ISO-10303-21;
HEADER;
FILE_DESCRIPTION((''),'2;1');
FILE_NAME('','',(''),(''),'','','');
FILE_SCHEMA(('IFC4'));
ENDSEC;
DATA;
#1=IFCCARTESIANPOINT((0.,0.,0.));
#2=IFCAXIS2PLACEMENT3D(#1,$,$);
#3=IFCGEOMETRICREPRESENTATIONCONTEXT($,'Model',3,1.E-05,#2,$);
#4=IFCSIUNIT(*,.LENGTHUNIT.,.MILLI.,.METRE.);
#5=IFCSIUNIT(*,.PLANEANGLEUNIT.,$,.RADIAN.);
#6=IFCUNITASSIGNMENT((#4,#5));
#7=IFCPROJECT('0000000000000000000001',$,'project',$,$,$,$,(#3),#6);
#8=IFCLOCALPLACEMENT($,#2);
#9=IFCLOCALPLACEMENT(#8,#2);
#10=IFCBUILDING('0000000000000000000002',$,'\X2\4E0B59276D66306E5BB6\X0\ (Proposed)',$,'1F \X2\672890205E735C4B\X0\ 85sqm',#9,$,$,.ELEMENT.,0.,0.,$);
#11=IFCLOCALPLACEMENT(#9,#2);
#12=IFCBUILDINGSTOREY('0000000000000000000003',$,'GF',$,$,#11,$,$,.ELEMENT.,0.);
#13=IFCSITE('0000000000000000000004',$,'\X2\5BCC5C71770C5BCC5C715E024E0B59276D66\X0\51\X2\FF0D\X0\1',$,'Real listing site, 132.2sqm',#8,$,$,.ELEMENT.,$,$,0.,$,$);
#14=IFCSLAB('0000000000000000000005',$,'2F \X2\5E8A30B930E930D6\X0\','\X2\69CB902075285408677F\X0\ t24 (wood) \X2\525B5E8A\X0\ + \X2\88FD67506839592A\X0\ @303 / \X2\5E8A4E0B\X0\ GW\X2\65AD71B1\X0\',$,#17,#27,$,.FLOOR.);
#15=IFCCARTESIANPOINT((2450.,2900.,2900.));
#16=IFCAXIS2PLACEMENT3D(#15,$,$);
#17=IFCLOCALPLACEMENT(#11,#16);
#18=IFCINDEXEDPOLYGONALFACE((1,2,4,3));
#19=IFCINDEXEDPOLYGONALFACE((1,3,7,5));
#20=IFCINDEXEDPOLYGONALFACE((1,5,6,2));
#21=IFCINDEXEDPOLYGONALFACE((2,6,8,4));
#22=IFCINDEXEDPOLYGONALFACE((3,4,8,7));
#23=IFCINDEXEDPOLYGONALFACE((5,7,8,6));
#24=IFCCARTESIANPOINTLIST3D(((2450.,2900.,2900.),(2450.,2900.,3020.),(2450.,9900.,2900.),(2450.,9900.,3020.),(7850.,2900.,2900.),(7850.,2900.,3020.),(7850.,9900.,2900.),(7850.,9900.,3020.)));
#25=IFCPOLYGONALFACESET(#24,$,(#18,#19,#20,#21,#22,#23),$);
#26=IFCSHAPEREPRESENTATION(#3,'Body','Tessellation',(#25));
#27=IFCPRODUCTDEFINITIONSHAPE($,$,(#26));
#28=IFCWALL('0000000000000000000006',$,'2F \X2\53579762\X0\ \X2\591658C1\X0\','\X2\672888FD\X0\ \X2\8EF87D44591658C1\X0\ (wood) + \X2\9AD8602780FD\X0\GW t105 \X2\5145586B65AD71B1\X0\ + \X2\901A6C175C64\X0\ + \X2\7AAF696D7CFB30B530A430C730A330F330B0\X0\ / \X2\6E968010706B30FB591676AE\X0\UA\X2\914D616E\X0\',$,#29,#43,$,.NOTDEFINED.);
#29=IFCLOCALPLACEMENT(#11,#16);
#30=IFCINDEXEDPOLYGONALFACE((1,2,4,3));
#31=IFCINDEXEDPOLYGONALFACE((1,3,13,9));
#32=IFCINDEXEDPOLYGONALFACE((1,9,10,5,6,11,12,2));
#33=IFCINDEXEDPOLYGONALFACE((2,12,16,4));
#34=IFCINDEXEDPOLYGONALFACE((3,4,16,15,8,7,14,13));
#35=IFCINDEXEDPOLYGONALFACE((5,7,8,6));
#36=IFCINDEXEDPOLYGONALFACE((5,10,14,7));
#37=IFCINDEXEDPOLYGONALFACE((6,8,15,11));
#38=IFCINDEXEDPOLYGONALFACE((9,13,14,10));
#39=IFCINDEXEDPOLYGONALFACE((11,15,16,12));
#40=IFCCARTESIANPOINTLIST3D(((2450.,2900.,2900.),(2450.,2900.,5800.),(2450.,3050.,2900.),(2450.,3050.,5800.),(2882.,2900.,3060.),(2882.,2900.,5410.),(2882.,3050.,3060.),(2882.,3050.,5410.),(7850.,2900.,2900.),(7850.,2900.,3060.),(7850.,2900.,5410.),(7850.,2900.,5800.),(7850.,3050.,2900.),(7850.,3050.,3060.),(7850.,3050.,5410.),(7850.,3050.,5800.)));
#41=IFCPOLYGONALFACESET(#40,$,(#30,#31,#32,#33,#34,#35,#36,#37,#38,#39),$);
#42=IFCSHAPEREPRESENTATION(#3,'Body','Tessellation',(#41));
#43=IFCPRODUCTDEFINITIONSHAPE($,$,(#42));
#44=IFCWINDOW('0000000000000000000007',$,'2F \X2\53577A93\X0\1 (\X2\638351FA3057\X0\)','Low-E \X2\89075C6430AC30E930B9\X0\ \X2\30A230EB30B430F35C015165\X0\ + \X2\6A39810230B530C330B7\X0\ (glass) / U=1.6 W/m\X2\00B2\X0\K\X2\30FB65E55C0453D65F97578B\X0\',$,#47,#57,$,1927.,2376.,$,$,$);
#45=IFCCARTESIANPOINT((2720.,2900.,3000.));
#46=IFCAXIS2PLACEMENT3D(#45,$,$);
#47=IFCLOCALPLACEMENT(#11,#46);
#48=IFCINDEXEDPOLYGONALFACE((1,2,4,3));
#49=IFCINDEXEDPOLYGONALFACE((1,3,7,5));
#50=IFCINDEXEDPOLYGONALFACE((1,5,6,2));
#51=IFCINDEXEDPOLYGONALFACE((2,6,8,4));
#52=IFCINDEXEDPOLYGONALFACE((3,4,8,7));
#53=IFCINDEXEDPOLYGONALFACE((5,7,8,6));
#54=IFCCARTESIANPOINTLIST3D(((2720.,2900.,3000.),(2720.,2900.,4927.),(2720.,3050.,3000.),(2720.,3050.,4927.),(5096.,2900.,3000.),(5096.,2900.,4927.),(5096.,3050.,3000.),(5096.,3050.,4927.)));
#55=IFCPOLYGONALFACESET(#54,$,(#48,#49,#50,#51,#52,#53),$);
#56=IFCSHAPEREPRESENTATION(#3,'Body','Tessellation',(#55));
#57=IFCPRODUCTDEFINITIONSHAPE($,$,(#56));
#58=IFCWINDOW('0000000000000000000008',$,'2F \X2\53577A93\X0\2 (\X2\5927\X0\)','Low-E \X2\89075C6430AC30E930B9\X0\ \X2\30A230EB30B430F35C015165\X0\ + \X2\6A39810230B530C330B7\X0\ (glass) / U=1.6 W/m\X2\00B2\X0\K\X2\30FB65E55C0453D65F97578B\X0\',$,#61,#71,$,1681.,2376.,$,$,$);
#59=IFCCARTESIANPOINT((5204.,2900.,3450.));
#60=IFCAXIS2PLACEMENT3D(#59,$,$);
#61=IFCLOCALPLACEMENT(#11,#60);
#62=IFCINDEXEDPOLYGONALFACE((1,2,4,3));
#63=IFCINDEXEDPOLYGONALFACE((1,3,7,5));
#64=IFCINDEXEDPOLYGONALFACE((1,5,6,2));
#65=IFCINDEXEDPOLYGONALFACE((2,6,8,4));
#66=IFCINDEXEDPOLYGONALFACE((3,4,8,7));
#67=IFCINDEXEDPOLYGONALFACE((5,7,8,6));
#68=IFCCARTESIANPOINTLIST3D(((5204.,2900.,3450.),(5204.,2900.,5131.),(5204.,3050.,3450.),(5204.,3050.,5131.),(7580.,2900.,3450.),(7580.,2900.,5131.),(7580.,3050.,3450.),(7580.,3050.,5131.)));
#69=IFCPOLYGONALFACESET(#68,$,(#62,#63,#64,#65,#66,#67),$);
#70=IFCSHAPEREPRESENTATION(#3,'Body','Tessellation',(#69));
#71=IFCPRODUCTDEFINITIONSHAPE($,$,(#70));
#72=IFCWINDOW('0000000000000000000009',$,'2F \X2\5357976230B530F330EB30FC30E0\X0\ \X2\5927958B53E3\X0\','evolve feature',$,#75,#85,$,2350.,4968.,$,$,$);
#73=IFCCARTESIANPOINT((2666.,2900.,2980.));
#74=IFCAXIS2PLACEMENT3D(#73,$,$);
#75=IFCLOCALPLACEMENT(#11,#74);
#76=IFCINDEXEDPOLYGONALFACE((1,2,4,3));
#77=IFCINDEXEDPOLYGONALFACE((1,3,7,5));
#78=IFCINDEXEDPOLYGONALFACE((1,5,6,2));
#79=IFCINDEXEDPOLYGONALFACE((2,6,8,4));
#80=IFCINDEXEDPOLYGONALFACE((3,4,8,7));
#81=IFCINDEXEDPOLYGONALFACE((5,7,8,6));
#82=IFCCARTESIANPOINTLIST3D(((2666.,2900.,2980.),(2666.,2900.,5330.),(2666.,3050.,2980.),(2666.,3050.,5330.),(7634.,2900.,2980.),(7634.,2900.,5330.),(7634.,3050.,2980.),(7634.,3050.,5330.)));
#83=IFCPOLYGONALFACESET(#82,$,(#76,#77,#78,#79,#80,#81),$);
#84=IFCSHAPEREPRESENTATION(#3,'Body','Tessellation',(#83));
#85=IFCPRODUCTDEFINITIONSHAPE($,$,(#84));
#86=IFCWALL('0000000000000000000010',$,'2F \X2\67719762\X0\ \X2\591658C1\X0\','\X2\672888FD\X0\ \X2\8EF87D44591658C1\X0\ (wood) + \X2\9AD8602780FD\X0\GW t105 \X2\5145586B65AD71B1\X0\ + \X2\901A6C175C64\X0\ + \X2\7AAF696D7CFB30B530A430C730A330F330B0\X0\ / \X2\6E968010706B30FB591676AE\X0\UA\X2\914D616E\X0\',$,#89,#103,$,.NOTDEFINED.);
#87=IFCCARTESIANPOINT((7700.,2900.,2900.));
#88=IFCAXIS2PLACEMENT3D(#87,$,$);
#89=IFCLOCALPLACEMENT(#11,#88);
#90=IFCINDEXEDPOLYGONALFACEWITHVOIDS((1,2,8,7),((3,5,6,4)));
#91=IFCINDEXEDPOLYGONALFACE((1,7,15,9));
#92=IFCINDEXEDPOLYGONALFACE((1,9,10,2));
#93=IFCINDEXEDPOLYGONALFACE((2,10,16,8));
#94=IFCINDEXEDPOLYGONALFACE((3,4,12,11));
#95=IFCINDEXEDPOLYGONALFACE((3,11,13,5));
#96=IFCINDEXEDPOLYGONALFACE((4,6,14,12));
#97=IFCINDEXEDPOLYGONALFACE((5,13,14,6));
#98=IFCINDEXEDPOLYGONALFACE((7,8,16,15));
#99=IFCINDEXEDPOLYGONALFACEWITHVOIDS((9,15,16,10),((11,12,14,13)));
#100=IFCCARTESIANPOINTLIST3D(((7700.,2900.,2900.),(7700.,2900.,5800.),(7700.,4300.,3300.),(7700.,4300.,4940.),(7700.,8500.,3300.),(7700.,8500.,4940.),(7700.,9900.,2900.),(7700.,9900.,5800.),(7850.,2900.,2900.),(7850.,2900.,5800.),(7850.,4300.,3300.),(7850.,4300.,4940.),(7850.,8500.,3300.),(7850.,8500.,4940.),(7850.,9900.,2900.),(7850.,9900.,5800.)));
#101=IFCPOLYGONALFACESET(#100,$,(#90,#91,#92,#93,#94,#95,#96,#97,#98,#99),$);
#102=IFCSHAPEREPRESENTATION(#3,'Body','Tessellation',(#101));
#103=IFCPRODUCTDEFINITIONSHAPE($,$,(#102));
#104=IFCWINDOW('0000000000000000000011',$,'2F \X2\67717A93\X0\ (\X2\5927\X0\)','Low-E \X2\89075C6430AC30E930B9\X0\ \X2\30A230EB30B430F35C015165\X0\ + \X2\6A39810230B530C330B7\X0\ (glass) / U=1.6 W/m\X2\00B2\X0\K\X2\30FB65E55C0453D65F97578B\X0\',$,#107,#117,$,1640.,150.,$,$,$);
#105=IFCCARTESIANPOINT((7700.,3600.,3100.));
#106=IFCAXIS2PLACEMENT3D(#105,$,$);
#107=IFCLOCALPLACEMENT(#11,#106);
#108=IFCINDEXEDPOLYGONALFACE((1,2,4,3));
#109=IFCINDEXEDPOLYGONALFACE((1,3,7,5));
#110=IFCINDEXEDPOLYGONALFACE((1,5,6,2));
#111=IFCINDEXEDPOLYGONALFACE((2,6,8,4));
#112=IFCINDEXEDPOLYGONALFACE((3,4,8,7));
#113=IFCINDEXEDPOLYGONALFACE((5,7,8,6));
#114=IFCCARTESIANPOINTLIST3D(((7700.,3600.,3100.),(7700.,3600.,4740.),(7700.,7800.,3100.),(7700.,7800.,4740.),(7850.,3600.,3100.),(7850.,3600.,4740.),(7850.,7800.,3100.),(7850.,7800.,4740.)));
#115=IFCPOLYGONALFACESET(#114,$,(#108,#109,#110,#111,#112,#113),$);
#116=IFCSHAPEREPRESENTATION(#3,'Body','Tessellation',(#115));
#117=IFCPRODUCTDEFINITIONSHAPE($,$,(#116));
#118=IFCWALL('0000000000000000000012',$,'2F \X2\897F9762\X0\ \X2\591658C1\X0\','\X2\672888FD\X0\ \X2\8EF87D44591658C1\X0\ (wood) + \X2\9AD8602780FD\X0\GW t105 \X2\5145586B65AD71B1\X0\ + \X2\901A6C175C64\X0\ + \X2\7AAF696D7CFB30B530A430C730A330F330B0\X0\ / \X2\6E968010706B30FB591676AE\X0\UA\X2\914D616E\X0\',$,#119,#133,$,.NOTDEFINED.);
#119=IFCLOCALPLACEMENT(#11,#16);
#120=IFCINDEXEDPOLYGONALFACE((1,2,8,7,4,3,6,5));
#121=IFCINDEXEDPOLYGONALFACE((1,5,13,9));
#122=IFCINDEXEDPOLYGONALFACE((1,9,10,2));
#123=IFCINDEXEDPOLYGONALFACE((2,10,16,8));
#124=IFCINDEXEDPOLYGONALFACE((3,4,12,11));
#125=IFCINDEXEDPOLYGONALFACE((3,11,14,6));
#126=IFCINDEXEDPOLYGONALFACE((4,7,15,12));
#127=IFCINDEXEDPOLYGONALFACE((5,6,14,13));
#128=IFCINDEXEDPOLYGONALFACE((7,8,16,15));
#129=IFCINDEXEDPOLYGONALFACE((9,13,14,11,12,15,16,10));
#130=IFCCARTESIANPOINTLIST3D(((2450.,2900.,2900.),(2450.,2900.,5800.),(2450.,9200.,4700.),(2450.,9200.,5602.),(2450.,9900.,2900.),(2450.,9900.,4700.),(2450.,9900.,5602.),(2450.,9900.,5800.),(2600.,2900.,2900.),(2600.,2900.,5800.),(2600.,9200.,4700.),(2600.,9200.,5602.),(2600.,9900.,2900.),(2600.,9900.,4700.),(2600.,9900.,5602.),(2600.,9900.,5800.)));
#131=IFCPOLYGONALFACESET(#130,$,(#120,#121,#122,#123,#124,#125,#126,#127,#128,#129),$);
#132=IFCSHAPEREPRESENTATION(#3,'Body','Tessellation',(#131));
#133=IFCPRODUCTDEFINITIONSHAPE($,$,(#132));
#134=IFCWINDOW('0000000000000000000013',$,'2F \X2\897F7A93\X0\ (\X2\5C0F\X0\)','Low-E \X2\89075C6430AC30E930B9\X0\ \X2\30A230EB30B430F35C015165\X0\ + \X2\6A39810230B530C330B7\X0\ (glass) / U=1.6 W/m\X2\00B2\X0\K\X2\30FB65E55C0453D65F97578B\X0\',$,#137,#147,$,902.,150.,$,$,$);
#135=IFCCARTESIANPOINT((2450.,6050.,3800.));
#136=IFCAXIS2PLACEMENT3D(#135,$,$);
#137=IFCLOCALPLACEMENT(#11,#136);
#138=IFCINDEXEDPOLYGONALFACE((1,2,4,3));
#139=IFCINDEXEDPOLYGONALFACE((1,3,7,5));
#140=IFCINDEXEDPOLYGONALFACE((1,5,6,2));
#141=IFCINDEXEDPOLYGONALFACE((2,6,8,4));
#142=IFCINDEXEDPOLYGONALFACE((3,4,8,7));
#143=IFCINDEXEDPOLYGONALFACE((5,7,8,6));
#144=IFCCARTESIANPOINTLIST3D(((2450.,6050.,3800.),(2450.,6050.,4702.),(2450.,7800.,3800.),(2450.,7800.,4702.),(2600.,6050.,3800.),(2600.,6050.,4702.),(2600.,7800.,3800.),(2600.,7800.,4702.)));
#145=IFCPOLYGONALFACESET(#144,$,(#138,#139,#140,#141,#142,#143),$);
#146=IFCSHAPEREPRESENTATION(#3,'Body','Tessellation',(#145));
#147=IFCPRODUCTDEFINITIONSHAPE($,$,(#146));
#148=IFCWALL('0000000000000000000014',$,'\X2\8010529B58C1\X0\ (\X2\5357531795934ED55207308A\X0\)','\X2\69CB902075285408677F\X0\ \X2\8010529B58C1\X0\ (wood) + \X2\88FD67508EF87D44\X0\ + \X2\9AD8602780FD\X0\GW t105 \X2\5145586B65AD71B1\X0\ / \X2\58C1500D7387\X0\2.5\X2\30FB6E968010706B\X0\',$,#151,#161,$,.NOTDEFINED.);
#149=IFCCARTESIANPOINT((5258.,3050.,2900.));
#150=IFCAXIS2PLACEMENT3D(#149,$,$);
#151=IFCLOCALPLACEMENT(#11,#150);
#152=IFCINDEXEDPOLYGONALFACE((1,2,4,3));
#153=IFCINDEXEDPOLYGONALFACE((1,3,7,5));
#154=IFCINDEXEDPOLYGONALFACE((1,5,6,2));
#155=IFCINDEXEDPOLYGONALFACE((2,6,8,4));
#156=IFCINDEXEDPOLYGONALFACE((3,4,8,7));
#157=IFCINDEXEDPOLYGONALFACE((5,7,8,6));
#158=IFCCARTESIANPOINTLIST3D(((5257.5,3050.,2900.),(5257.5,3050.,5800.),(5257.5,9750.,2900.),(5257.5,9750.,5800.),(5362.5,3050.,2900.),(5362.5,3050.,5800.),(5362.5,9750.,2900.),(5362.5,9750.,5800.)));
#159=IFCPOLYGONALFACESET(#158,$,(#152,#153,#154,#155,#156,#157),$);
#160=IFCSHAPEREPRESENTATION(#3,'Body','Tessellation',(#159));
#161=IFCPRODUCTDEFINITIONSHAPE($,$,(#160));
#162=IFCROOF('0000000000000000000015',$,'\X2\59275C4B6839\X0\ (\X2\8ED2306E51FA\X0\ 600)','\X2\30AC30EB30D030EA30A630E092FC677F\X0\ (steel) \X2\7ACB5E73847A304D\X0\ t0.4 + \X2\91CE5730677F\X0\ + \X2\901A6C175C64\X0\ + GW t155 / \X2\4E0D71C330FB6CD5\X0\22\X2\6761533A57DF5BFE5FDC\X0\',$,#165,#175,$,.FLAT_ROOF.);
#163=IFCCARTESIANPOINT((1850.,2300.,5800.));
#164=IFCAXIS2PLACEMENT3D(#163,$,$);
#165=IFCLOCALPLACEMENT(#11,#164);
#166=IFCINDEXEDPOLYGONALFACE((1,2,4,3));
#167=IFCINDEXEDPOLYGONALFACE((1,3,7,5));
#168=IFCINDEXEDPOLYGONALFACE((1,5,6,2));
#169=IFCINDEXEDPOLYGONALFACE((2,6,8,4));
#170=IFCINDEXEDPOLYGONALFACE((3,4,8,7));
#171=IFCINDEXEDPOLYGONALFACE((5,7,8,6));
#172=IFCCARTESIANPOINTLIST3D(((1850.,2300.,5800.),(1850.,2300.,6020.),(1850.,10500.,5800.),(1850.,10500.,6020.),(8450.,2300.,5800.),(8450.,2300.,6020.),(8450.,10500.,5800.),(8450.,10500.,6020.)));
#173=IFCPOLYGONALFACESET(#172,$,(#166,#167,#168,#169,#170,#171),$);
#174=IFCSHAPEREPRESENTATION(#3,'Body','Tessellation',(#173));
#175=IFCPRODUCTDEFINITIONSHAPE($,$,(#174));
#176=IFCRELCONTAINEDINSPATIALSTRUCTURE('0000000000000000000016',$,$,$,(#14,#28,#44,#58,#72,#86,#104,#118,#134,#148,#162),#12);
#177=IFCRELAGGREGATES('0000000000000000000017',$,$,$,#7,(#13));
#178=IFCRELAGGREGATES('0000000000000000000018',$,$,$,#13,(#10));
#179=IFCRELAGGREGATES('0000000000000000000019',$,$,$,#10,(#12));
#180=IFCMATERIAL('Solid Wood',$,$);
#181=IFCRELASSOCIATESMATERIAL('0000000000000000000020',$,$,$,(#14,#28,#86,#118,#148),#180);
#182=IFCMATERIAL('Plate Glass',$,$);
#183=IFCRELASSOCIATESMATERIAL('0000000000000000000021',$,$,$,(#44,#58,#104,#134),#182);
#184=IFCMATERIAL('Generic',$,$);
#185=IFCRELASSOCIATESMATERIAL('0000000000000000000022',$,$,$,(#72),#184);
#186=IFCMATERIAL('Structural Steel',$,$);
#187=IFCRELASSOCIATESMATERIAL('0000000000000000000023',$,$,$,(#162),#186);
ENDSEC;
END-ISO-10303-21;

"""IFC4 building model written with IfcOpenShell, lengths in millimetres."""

from ifc_helpers import new_model, si_unit, frame, frame_2d, origin, place, context, project, spatial, rectangle, extrude, material, element, fill, save


model = new_model("IFC4")

# Units and contexts
model_context = context("Model", 3, precision=1e-05, world=origin())
ifc_project = project(units=[si_unit("LENGTHUNIT", "METRE", prefix="MILLI"), si_unit("PLANEANGLEUNIT", "RADIAN")], contexts=[model_context])

# Site, building, storey
site_placement = place(None, origin())
site = spatial("IfcSite", under=ifc_project, at=site_placement, Name="富山県富山市下大浦51－1", ObjectType="Real listing site, 132.2sqm", CompositionType="ELEMENT", RefElevation=0.0)
building_placement = place(site_placement, origin())
building = spatial("IfcBuilding", under=site, at=building_placement, Name="下大浦の家 (Proposed)", ObjectType="1F 木造平屋 85sqm", CompositionType="ELEMENT", ElevationOfRefHeight=0.0, ElevationOfTerrain=0.0)
storey_placement = place(building_placement, origin())
storey = spatial("IfcBuildingStorey", under=building, at=storey_placement, Name="GF", CompositionType="ELEMENT", Elevation=0.0)

# Slab
ifc_material_1 = material(Name="Solid Wood")
slab_placement = place(storey_placement, frame((2450.0, 2900.0, 2900.0)))
element("IfcSlab", 1, at=slab_placement, inside=storey, material=ifc_material_1, Name="2F 床スラブ", Description="構造用合板 t24 (wood) 剛床 + 製材根太 @303 / 床下 GW断熱", PredefinedType="FLOOR", context=model_context, shape_type="SweptSolid", body=[
    extrude(rectangle(XDim=5400.0, YDim=7000.0, at=frame_2d((2700.0, 3500.0))), frame((2450.0, 2900.0, 2900.0)), (0.0, 0.0, 1.0), 120.0),
])

# Wall, openings, windows
wall_1_placement = place(storey_placement, frame((2450.0, 2900.0, 2900.0)))
wall_1 = element("IfcWall", 2, at=wall_1_placement, inside=storey, material=ifc_material_1, Name="2F 南面 外壁", Description="木製 軸組外壁 (wood) + 高性能GW t105 充填断熱 + 通気層 + 窯業系サイディング / 準耐火・外皮UA配慮", PredefinedType="NOTDEFINED", context=model_context, shape_type="SweptSolid", body=[
    extrude(rectangle(XDim=5400.0, YDim=150.0, at=frame_2d((2700.0, 75.0))), frame((2450.0, 2900.0, 2900.0)), (0.0, 0.0, 1.0), 2900.0),
])
opening_1_placement = place(storey_placement, frame((2720.0, 2900.0, 3000.0)))
opening_1 = element("IfcOpeningElement", 3, at=opening_1_placement, cuts=wall_1, PredefinedType="NOTDEFINED", context=model_context, shape_type="SweptSolid", body=[
    extrude(rectangle(XDim=2376.0, YDim=150.0, at=frame_2d((1188.0, 75.0))), frame((2720.0, 2900.0, 3000.0)), (0.0, 0.0, 1.0), 1927.0),
])
opening_2_placement = place(storey_placement, frame((5204.0, 2900.0, 3450.0)))
opening_2 = element("IfcOpeningElement", 4, at=opening_2_placement, cuts=wall_1, PredefinedType="NOTDEFINED", context=model_context, shape_type="SweptSolid", body=[
    extrude(rectangle(XDim=2376.0, YDim=150.0, at=frame_2d((1188.0, 75.0))), frame((5204.0, 2900.0, 3450.0)), (0.0, 0.0, 1.0), 1681.0),
])
opening_3_placement = place(storey_placement, frame((2666.0, 2900.0, 2980.0)))
opening_3 = element("IfcOpeningElement", 5, at=opening_3_placement, cuts=wall_1, PredefinedType="NOTDEFINED", context=model_context, shape_type="SweptSolid", body=[
    extrude(rectangle(XDim=4968.0, YDim=150.0, at=frame_2d((2484.0, 75.0))), frame((2666.0, 2900.0, 2980.0)), (0.0, 0.0, 1.0), 2350.0),
])
ifc_material_2 = material(Name="Plate Glass")
window_1_placement = place(storey_placement, frame((2720.0, 2900.0, 3000.0)))
window_1 = element("IfcWindow", 6, at=window_1_placement, inside=storey, material=ifc_material_2, Name="2F 南窓1 (掃出し)", Description="Low-E 複層ガラス アルゴン封入 + 樹脂サッシ (glass) / U=1.6 W/m²K・日射取得型", OverallHeight=1927.0, OverallWidth=2376.0, context=model_context, shape_type="SweptSolid", body=[
    extrude(rectangle(XDim=2376.0, YDim=150.0, at=frame_2d((1188.0, 75.0))), frame((2720.0, 2900.0, 3000.0)), (0.0, 0.0, 1.0), 1927.0),
])
fill(opening_1, window_1)
window_2_placement = place(storey_placement, frame((5204.0, 2900.0, 3450.0)))
window_2 = element("IfcWindow", 7, at=window_2_placement, inside=storey, material=ifc_material_2, Name="2F 南窓2 (大)", Description="Low-E 複層ガラス アルゴン封入 + 樹脂サッシ (glass) / U=1.6 W/m²K・日射取得型", OverallHeight=1681.0, OverallWidth=2376.0, context=model_context, shape_type="SweptSolid", body=[
    extrude(rectangle(XDim=2376.0, YDim=150.0, at=frame_2d((1188.0, 75.0))), frame((5204.0, 2900.0, 3450.0)), (0.0, 0.0, 1.0), 1681.0),
])
fill(opening_2, window_2)
ifc_material_3 = material(Name="Generic")
window_3_placement = place(storey_placement, frame((2666.0, 2900.0, 2980.0)))
window_3 = element("IfcWindow", 8, at=window_3_placement, inside=storey, material=ifc_material_3, Name="2F 南面サンルーム 大開口", Description="evolve feature", OverallHeight=2350.0, OverallWidth=4968.0, context=model_context, shape_type="SweptSolid", body=[
    extrude(rectangle(XDim=4968.0, YDim=150.0, at=frame_2d((2484.0, 75.0))), frame((2666.0, 2900.0, 2980.0)), (0.0, 0.0, 1.0), 2350.0),
])
fill(opening_3, window_3)

# Walls, openings, windows
wall_2_placement = place(storey_placement, frame((7700.0, 2900.0, 2900.0)))
wall_2 = element("IfcWall", 9, at=wall_2_placement, inside=storey, material=ifc_material_1, Name="2F 東面 外壁", Description="木製 軸組外壁 (wood) + 高性能GW t105 充填断熱 + 通気層 + 窯業系サイディング / 準耐火・外皮UA配慮", PredefinedType="NOTDEFINED", context=model_context, shape_type="SweptSolid", body=[
    extrude(rectangle(XDim=150.0, YDim=7000.0, at=frame_2d((75.0, 3500.0))), frame((7700.0, 2900.0, 2900.0)), (0.0, 0.0, 1.0), 2900.0),
])
opening_4_placement = place(storey_placement, frame((7700.0, 3600.0, 3100.0)))
opening_4 = element("IfcOpeningElement", 10, at=opening_4_placement, cuts=wall_2, PredefinedType="NOTDEFINED", context=model_context, shape_type="SweptSolid", body=[
    extrude(rectangle(XDim=150.0, YDim=4200.0, at=frame_2d((75.0, 2100.0))), frame((7700.0, 3600.0, 3100.0)), (0.0, 0.0, 1.0), 1640.0),
])
window_4_placement = place(storey_placement, frame((7700.0, 3600.0, 3100.0)))
window_4 = element("IfcWindow", 11, at=window_4_placement, inside=storey, material=ifc_material_2, Name="2F 東窓 (大)", Description="Low-E 複層ガラス アルゴン封入 + 樹脂サッシ (glass) / U=1.6 W/m²K・日射取得型", OverallHeight=1640.0, OverallWidth=150.0, context=model_context, shape_type="SweptSolid", body=[
    extrude(rectangle(XDim=150.0, YDim=4200.0, at=frame_2d((75.0, 2100.0))), frame((7700.0, 3600.0, 3100.0)), (0.0, 0.0, 1.0), 1640.0),
])
fill(opening_4, window_4)
wall_3_placement = place(storey_placement, frame((2450.0, 2900.0, 2900.0)))
wall_3 = element("IfcWall", 12, at=wall_3_placement, inside=storey, material=ifc_material_1, Name="2F 西面 外壁", Description="木製 軸組外壁 (wood) + 高性能GW t105 充填断熱 + 通気層 + 窯業系サイディング / 準耐火・外皮UA配慮", PredefinedType="NOTDEFINED", context=model_context, shape_type="SweptSolid", body=[
    extrude(rectangle(XDim=150.0, YDim=7000.0, at=frame_2d((75.0, 3500.0))), frame((2450.0, 2900.0, 2900.0)), (0.0, 0.0, 1.0), 2900.0),
])
opening_5_placement = place(storey_placement, frame((2450.0, 6050.0, 3800.0)))
opening_5 = element("IfcOpeningElement", 13, at=opening_5_placement, cuts=wall_3, PredefinedType="NOTDEFINED", context=model_context, shape_type="SweptSolid", body=[
    extrude(rectangle(XDim=150.0, YDim=1750.0, at=frame_2d((75.0, 875.0))), frame((2450.0, 6050.0, 3800.0)), (0.0, 0.0, 1.0), 902.0),
])
window_5_placement = place(storey_placement, frame((2450.0, 6050.0, 3800.0)))
window_5 = element("IfcWindow", 14, at=window_5_placement, inside=storey, material=ifc_material_2, Name="2F 西窓 (小)", Description="Low-E 複層ガラス アルゴン封入 + 樹脂サッシ (glass) / U=1.6 W/m²K・日射取得型", OverallHeight=902.0, OverallWidth=150.0, context=model_context, shape_type="SweptSolid", body=[
    extrude(rectangle(XDim=150.0, YDim=1750.0, at=frame_2d((75.0, 875.0))), frame((2450.0, 6050.0, 3800.0)), (0.0, 0.0, 1.0), 902.0),
])
fill(opening_5, window_5)

# Wall
wall_4_placement = place(storey_placement, frame((5258.0, 3050.0, 2900.0)))
element("IfcWall", 15, at=wall_4_placement, inside=storey, material=ifc_material_1, Name="耐力壁 (南北間仕切り)", Description="構造用合板 耐力壁 (wood) + 製材軸組 + 高性能GW t105 充填断熱 / 壁倍率2.5・準耐火", PredefinedType="NOTDEFINED", context=model_context, shape_type="SweptSolid", body=[
    extrude(rectangle(XDim=105.0, YDim=6700.0, at=frame_2d((52.0, 3350.0))), frame((5258.0, 3050.0, 2900.0)), (0.0, 0.0, 1.0), 2900.0),
])

# Roof
ifc_material_4 = material(Name="Structural Steel")
roof_1_placement = place(storey_placement, frame((1850.0, 2300.0, 5800.0)))
element("IfcRoof", 16, at=roof_1_placement, inside=storey, material=ifc_material_4, Name="大屋根 (軒の出 600)", Description="ガルバリウム鋼板 (steel) 立平葺き t0.4 + 野地板 + 通気層 + GW t155 / 不燃・法22条区域対応", PredefinedType="FLAT_ROOF", context=model_context, shape_type="SweptSolid", body=[
    extrude(rectangle(XDim=6600.0, YDim=8200.0, at=frame_2d((3300.0, 4100.0))), frame((1850.0, 2300.0, 5800.0)), (0.0, 0.0, 1.0), 220.0),
])

save(model, "model.ifc")
